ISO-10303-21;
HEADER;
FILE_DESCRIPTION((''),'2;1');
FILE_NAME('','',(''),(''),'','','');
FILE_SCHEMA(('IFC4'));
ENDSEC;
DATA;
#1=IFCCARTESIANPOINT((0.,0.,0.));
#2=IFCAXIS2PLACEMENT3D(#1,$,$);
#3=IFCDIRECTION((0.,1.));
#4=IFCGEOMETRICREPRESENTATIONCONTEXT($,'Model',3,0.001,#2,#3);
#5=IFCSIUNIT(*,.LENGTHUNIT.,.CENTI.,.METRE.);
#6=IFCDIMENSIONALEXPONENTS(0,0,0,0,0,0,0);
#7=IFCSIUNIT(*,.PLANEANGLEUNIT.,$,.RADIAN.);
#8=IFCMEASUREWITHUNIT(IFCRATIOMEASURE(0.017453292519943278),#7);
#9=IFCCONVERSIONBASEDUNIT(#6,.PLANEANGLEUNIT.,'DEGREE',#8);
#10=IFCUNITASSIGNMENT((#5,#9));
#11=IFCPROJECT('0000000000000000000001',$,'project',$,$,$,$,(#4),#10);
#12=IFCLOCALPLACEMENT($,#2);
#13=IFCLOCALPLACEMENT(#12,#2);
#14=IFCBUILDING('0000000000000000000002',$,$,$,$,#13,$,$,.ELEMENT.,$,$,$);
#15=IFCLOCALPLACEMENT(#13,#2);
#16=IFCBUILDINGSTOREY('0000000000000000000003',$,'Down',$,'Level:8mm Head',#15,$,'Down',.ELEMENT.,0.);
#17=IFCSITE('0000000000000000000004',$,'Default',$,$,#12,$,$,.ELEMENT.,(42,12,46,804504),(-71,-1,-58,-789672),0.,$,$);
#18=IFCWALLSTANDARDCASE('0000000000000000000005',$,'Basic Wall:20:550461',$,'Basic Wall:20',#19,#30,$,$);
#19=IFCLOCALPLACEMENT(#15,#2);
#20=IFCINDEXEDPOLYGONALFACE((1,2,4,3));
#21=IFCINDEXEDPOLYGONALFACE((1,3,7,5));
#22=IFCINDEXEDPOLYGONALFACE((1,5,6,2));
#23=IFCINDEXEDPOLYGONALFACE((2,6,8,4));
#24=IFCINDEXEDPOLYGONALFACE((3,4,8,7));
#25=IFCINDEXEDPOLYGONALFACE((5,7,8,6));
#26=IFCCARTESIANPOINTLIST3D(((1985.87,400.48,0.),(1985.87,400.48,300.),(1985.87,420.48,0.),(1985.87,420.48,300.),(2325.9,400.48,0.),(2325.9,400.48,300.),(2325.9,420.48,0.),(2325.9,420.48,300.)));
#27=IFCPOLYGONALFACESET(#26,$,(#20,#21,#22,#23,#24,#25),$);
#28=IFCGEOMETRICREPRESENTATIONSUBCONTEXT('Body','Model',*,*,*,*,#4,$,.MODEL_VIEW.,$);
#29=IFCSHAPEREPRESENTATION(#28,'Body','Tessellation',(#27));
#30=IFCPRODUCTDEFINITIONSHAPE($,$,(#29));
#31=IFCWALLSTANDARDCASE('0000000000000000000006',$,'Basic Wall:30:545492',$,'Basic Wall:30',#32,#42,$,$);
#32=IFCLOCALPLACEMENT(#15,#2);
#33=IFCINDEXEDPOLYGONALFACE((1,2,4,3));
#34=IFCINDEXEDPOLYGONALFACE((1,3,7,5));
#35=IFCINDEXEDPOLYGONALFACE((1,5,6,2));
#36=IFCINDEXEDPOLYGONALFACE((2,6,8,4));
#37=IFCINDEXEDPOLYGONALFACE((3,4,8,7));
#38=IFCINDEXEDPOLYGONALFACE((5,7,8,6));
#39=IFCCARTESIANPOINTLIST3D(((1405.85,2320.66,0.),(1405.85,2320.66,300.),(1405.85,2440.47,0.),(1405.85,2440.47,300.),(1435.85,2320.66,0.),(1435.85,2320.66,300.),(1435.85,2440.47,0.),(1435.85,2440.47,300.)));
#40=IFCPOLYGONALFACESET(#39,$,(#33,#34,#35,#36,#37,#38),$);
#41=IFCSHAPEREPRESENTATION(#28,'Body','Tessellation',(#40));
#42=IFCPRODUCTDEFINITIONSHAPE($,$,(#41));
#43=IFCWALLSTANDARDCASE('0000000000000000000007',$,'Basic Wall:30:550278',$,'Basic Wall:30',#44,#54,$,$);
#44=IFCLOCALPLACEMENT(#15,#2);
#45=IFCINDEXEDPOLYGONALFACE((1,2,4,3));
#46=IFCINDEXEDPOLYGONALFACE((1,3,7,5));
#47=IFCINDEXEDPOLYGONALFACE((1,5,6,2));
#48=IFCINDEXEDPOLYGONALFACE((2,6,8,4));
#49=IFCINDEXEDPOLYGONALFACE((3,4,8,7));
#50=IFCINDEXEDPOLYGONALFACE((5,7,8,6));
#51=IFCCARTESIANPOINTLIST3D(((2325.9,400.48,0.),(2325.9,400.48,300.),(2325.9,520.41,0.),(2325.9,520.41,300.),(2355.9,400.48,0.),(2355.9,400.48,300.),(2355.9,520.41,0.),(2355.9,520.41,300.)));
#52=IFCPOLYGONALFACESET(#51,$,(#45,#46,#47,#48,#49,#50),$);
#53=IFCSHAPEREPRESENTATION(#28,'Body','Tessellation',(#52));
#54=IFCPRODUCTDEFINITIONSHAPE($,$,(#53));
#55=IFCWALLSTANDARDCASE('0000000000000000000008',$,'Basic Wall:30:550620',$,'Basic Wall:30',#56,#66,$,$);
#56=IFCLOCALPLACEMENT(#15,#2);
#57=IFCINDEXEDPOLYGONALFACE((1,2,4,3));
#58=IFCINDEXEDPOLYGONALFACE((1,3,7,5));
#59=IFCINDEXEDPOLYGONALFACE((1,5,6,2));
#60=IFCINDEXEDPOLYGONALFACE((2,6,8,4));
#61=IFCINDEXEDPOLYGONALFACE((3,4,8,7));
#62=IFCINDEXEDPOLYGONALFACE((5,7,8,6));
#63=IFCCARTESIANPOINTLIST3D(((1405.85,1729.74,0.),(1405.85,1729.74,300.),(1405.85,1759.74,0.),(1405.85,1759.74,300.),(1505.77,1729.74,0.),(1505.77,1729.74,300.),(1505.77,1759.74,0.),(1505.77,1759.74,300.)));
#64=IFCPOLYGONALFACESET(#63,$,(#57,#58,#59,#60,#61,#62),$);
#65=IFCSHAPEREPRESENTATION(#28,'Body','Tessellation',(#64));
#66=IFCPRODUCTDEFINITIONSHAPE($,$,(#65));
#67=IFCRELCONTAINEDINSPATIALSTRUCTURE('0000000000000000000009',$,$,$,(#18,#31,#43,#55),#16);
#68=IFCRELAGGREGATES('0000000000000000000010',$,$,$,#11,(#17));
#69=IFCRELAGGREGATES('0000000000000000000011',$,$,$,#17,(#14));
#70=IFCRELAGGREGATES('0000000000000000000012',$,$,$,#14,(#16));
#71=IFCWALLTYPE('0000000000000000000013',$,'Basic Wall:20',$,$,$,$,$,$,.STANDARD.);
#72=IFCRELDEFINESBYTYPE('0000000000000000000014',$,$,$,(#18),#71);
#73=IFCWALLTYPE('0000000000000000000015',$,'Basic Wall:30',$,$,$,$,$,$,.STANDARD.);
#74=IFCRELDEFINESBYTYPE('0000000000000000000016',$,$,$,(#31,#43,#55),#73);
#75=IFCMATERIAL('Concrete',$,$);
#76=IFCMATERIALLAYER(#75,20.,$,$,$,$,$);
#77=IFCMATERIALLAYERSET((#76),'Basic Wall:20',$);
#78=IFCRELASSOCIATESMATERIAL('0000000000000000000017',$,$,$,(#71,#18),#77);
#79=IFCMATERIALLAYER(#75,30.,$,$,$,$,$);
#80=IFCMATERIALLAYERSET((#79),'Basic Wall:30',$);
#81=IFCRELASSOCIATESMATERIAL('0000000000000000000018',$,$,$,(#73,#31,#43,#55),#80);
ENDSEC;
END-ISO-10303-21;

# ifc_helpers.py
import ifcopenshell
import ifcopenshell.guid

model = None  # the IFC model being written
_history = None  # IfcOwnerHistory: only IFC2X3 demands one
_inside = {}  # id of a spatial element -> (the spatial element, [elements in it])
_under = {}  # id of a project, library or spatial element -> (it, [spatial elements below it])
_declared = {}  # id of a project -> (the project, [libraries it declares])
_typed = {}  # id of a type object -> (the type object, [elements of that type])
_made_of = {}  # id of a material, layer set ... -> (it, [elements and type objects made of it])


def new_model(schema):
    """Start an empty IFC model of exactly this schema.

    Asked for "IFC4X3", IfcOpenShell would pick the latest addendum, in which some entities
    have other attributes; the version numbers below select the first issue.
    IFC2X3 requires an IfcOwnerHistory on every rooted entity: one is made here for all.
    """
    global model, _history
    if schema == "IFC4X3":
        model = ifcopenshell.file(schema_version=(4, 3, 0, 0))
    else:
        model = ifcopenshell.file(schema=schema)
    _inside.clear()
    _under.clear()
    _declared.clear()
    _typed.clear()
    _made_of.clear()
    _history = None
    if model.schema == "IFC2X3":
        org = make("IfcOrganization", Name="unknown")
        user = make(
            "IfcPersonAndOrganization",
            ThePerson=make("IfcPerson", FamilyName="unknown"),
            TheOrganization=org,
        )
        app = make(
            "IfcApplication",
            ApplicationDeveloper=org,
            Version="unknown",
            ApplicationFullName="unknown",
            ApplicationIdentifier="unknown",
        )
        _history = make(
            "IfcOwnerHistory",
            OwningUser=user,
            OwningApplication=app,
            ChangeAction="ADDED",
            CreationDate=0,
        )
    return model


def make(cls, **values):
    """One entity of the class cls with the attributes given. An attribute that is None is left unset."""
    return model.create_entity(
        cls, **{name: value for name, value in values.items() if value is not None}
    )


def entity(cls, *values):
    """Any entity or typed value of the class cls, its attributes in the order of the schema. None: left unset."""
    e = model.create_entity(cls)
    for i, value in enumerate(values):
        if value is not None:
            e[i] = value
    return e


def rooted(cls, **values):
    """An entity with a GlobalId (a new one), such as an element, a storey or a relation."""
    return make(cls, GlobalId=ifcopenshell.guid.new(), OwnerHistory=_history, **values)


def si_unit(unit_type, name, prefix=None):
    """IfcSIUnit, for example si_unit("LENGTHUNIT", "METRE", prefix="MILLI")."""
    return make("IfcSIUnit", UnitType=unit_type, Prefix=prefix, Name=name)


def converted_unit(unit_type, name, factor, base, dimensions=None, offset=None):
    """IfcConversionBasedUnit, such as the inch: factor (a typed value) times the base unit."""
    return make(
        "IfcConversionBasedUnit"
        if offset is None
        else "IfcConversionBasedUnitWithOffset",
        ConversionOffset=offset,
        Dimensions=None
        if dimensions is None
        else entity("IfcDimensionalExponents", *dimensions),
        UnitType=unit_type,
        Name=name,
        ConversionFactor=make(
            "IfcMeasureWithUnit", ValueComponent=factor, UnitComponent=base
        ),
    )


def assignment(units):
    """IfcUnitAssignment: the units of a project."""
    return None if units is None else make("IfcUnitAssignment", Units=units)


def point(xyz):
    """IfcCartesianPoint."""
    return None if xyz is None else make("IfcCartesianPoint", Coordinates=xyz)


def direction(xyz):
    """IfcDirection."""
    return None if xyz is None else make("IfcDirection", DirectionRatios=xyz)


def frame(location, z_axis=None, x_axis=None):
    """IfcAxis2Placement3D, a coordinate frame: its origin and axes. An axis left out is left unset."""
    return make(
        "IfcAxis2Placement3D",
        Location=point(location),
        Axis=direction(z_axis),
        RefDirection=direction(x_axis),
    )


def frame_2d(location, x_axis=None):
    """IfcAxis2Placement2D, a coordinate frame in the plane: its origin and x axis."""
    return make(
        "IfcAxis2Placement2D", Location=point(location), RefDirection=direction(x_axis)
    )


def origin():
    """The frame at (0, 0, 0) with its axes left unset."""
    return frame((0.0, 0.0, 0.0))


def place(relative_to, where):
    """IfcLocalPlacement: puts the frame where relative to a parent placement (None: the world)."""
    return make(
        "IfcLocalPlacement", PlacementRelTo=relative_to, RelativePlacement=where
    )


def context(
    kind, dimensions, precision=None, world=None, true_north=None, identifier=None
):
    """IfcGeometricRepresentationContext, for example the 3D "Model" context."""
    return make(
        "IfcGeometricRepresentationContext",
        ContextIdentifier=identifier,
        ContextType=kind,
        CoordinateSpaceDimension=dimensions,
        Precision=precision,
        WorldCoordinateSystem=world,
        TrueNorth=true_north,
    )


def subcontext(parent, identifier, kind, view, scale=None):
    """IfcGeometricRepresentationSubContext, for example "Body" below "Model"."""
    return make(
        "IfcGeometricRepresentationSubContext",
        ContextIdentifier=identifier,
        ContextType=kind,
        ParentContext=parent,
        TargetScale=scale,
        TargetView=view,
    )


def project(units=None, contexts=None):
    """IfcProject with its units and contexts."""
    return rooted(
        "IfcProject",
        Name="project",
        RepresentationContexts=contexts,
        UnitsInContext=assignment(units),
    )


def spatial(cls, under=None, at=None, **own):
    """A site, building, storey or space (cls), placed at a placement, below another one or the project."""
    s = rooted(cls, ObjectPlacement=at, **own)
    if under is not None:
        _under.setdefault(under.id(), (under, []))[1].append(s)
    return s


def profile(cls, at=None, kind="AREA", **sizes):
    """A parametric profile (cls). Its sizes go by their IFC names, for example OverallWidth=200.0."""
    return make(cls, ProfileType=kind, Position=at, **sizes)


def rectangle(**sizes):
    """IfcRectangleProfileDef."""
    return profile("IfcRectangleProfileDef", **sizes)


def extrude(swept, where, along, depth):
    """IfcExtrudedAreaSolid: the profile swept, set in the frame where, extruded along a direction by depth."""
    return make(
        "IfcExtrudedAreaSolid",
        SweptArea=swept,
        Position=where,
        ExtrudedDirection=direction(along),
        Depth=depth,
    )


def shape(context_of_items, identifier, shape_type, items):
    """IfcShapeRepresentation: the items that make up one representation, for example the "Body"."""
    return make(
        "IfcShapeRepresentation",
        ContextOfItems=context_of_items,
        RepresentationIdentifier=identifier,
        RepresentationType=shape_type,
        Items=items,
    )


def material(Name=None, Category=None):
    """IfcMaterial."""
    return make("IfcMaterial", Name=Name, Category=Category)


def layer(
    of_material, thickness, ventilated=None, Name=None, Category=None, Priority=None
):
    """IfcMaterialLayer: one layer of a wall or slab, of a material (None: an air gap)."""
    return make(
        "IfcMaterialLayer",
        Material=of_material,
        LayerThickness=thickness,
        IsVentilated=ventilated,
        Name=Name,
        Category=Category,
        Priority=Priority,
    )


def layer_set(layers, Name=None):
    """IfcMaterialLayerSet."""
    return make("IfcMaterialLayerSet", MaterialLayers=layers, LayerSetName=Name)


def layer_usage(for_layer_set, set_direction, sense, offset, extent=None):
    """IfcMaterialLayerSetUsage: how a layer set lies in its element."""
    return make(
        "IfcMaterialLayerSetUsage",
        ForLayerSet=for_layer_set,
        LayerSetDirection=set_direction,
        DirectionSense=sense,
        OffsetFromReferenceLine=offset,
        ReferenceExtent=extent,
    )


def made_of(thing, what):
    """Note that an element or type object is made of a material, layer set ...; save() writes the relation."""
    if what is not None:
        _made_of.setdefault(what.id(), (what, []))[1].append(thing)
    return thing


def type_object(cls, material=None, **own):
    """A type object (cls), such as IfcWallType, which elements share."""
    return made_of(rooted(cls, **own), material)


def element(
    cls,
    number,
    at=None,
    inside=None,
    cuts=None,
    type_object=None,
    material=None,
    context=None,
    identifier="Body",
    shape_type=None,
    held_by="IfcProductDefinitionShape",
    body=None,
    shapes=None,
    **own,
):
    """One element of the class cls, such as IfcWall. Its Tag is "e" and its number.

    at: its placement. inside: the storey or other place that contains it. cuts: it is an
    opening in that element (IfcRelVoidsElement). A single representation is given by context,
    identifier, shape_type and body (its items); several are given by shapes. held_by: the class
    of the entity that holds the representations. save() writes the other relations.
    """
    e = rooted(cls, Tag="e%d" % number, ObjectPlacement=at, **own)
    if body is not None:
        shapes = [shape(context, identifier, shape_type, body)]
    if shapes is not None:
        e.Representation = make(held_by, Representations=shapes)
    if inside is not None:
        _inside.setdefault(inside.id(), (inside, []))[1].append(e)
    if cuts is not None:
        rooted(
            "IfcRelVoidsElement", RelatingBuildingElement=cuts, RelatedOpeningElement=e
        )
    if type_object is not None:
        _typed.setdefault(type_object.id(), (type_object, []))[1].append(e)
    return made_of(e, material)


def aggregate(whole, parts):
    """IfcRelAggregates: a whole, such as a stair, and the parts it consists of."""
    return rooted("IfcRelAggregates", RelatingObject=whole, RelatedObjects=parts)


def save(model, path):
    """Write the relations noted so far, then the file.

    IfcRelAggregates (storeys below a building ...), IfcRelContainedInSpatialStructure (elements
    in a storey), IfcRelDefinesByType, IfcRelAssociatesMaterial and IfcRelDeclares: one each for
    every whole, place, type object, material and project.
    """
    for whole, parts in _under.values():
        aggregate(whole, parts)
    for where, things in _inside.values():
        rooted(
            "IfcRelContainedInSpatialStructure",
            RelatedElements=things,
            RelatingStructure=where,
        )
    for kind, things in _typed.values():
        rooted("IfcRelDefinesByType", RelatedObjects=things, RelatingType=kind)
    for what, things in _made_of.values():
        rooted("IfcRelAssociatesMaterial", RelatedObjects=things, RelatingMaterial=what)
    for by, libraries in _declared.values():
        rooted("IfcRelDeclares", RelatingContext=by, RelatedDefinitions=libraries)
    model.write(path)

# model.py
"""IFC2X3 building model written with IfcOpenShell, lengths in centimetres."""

from ifc_helpers import new_model, entity, si_unit, converted_unit, direction, frame, frame_2d, origin, place, context, subcontext, project, spatial, rectangle, extrude, material, layer, layer_set, layer_usage, type_object, element, save


model = new_model("IFC2X3")

# Units and contexts
model_context = context("Model", 3, precision=0.001, world=origin(), true_north=direction((0.0, 1.0)))
body_context = subcontext(model_context, "Body", "Model", "MODEL_VIEW")
ifc_project = project(units=[si_unit("LENGTHUNIT", "METRE", prefix="CENTI"), converted_unit("PLANEANGLEUNIT", "DEGREE", entity("IfcRatioMeasure", 0.017453292519943278), si_unit("PLANEANGLEUNIT", "RADIAN"), dimensions=[0, 0, 0, 0, 0, 0, 0])], contexts=[model_context])

# Site, building, storey
site_placement = place(None, origin())
site = spatial("IfcSite", under=ifc_project, at=site_placement, Name="Default", CompositionType="ELEMENT", RefLatitude=(42, 12, 46, 804504), RefLongitude=(-71, -1, -58, -789672), RefElevation=0.0)
building_placement = place(site_placement, origin())
building = spatial("IfcBuilding", under=site, at=building_placement, CompositionType="ELEMENT")
storey_placement = place(building_placement, origin())
storey = spatial("IfcBuildingStorey", under=building, at=storey_placement, Name="Down", ObjectType="Level:8mm Head", LongName="Down", CompositionType="ELEMENT", Elevation=0.0)

# Shared definitions
ifc_material = material(Name="Concrete")

# Walls
ifc_layer_1 = layer(ifc_material, 20.0)
ifc_layer_set_1 = layer_set([ifc_layer_1], Name="Basic Wall:20")
wall_type_1 = type_object("IfcWallType", Name="Basic Wall:20", PredefinedType="STANDARD", material=ifc_layer_set_1)
ifc_layer_usage_1 = layer_usage(ifc_layer_set_1, "AXIS2", "NEGATIVE", 10.0)
wall_1_placement = place(storey_placement, frame((2325.9, 410.48, 0.0), z_axis=(0.0, 0.0, 1.0), x_axis=(-1.0, 0.0, 0.0)))
element("IfcWallStandardCase", 1, at=wall_1_placement, inside=storey, type_object=wall_type_1, material=ifc_layer_usage_1, Name="Basic Wall:20:550461", ObjectType="Basic Wall:20", context=body_context, shape_type="SweptSolid", body=[
    extrude(rectangle(XDim=340.03, YDim=20.0, at=frame_2d((170.01, 0.0), x_axis=(-1.0, 0.0))), origin(), (0.0, 0.0, 1.0), 300.0),
])
ifc_layer_2 = layer(ifc_material, 30.0)
ifc_layer_set_2 = layer_set([ifc_layer_2], Name="Basic Wall:30")
ifc_layer_usage_2 = layer_usage(ifc_layer_set_2, "AXIS2", "NEGATIVE", 15.0)
wall_type_2 = type_object("IfcWallType", Name="Basic Wall:30", PredefinedType="STANDARD", material=ifc_layer_set_2)
wall_2_placement = place(storey_placement, frame((1420.85, 2320.66, 0.0), z_axis=(0.0, 0.0, 1.0), x_axis=(0.0, 1.0, 0.0)))
element("IfcWallStandardCase", 2, at=wall_2_placement, inside=storey, type_object=wall_type_2, material=ifc_layer_usage_2, Name="Basic Wall:30:545492", ObjectType="Basic Wall:30", context=body_context, shape_type="SweptSolid", body=[
    extrude(rectangle(XDim=119.81, YDim=30.0, at=frame_2d((59.91, 0.0), x_axis=(-1.0, 0.0))), origin(), (0.0, 0.0, 1.0), 300.0),
])
ifc_layer_usage_3 = layer_usage(ifc_layer_set_2, "AXIS2", "NEGATIVE", 15.0)
wall_3_placement = place(storey_placement, frame((2340.9, 520.41, 0.0), z_axis=(0.0, 0.0, 1.0), x_axis=(0.0, -1.0, 0.0)))
element("IfcWallStandardCase", 3, at=wall_3_placement, inside=storey, type_object=wall_type_2, material=ifc_layer_usage_3, Name="Basic Wall:30:550278", ObjectType="Basic Wall:30", context=body_context, shape_type="SweptSolid", body=[
    extrude(rectangle(XDim=119.93, YDim=30.0, at=frame_2d((59.97, 0.0), x_axis=(-1.0, 0.0))), origin(), (0.0, 0.0, 1.0), 300.0),
])
ifc_layer_usage_4 = layer_usage(ifc_layer_set_2, "AXIS2", "POSITIVE", -15.0)
wall_4_placement = place(storey_placement, frame((1505.77, 1744.74, 0.0), z_axis=(0.0, 0.0, 1.0), x_axis=(-1.0, 0.0, 0.0)))
element("IfcWallStandardCase", 4, at=wall_4_placement, inside=storey, type_object=wall_type_2, material=ifc_layer_usage_4, Name="Basic Wall:30:550620", ObjectType="Basic Wall:30", context=body_context, shape_type="SweptSolid", body=[
    extrude(rectangle(XDim=99.92, YDim=30.0, at=frame_2d((49.96, 0.0), x_axis=(-1.0, 0.0))), origin(), (0.0, 0.0, 1.0), 300.0),
])

save(model, "model.ifc")
